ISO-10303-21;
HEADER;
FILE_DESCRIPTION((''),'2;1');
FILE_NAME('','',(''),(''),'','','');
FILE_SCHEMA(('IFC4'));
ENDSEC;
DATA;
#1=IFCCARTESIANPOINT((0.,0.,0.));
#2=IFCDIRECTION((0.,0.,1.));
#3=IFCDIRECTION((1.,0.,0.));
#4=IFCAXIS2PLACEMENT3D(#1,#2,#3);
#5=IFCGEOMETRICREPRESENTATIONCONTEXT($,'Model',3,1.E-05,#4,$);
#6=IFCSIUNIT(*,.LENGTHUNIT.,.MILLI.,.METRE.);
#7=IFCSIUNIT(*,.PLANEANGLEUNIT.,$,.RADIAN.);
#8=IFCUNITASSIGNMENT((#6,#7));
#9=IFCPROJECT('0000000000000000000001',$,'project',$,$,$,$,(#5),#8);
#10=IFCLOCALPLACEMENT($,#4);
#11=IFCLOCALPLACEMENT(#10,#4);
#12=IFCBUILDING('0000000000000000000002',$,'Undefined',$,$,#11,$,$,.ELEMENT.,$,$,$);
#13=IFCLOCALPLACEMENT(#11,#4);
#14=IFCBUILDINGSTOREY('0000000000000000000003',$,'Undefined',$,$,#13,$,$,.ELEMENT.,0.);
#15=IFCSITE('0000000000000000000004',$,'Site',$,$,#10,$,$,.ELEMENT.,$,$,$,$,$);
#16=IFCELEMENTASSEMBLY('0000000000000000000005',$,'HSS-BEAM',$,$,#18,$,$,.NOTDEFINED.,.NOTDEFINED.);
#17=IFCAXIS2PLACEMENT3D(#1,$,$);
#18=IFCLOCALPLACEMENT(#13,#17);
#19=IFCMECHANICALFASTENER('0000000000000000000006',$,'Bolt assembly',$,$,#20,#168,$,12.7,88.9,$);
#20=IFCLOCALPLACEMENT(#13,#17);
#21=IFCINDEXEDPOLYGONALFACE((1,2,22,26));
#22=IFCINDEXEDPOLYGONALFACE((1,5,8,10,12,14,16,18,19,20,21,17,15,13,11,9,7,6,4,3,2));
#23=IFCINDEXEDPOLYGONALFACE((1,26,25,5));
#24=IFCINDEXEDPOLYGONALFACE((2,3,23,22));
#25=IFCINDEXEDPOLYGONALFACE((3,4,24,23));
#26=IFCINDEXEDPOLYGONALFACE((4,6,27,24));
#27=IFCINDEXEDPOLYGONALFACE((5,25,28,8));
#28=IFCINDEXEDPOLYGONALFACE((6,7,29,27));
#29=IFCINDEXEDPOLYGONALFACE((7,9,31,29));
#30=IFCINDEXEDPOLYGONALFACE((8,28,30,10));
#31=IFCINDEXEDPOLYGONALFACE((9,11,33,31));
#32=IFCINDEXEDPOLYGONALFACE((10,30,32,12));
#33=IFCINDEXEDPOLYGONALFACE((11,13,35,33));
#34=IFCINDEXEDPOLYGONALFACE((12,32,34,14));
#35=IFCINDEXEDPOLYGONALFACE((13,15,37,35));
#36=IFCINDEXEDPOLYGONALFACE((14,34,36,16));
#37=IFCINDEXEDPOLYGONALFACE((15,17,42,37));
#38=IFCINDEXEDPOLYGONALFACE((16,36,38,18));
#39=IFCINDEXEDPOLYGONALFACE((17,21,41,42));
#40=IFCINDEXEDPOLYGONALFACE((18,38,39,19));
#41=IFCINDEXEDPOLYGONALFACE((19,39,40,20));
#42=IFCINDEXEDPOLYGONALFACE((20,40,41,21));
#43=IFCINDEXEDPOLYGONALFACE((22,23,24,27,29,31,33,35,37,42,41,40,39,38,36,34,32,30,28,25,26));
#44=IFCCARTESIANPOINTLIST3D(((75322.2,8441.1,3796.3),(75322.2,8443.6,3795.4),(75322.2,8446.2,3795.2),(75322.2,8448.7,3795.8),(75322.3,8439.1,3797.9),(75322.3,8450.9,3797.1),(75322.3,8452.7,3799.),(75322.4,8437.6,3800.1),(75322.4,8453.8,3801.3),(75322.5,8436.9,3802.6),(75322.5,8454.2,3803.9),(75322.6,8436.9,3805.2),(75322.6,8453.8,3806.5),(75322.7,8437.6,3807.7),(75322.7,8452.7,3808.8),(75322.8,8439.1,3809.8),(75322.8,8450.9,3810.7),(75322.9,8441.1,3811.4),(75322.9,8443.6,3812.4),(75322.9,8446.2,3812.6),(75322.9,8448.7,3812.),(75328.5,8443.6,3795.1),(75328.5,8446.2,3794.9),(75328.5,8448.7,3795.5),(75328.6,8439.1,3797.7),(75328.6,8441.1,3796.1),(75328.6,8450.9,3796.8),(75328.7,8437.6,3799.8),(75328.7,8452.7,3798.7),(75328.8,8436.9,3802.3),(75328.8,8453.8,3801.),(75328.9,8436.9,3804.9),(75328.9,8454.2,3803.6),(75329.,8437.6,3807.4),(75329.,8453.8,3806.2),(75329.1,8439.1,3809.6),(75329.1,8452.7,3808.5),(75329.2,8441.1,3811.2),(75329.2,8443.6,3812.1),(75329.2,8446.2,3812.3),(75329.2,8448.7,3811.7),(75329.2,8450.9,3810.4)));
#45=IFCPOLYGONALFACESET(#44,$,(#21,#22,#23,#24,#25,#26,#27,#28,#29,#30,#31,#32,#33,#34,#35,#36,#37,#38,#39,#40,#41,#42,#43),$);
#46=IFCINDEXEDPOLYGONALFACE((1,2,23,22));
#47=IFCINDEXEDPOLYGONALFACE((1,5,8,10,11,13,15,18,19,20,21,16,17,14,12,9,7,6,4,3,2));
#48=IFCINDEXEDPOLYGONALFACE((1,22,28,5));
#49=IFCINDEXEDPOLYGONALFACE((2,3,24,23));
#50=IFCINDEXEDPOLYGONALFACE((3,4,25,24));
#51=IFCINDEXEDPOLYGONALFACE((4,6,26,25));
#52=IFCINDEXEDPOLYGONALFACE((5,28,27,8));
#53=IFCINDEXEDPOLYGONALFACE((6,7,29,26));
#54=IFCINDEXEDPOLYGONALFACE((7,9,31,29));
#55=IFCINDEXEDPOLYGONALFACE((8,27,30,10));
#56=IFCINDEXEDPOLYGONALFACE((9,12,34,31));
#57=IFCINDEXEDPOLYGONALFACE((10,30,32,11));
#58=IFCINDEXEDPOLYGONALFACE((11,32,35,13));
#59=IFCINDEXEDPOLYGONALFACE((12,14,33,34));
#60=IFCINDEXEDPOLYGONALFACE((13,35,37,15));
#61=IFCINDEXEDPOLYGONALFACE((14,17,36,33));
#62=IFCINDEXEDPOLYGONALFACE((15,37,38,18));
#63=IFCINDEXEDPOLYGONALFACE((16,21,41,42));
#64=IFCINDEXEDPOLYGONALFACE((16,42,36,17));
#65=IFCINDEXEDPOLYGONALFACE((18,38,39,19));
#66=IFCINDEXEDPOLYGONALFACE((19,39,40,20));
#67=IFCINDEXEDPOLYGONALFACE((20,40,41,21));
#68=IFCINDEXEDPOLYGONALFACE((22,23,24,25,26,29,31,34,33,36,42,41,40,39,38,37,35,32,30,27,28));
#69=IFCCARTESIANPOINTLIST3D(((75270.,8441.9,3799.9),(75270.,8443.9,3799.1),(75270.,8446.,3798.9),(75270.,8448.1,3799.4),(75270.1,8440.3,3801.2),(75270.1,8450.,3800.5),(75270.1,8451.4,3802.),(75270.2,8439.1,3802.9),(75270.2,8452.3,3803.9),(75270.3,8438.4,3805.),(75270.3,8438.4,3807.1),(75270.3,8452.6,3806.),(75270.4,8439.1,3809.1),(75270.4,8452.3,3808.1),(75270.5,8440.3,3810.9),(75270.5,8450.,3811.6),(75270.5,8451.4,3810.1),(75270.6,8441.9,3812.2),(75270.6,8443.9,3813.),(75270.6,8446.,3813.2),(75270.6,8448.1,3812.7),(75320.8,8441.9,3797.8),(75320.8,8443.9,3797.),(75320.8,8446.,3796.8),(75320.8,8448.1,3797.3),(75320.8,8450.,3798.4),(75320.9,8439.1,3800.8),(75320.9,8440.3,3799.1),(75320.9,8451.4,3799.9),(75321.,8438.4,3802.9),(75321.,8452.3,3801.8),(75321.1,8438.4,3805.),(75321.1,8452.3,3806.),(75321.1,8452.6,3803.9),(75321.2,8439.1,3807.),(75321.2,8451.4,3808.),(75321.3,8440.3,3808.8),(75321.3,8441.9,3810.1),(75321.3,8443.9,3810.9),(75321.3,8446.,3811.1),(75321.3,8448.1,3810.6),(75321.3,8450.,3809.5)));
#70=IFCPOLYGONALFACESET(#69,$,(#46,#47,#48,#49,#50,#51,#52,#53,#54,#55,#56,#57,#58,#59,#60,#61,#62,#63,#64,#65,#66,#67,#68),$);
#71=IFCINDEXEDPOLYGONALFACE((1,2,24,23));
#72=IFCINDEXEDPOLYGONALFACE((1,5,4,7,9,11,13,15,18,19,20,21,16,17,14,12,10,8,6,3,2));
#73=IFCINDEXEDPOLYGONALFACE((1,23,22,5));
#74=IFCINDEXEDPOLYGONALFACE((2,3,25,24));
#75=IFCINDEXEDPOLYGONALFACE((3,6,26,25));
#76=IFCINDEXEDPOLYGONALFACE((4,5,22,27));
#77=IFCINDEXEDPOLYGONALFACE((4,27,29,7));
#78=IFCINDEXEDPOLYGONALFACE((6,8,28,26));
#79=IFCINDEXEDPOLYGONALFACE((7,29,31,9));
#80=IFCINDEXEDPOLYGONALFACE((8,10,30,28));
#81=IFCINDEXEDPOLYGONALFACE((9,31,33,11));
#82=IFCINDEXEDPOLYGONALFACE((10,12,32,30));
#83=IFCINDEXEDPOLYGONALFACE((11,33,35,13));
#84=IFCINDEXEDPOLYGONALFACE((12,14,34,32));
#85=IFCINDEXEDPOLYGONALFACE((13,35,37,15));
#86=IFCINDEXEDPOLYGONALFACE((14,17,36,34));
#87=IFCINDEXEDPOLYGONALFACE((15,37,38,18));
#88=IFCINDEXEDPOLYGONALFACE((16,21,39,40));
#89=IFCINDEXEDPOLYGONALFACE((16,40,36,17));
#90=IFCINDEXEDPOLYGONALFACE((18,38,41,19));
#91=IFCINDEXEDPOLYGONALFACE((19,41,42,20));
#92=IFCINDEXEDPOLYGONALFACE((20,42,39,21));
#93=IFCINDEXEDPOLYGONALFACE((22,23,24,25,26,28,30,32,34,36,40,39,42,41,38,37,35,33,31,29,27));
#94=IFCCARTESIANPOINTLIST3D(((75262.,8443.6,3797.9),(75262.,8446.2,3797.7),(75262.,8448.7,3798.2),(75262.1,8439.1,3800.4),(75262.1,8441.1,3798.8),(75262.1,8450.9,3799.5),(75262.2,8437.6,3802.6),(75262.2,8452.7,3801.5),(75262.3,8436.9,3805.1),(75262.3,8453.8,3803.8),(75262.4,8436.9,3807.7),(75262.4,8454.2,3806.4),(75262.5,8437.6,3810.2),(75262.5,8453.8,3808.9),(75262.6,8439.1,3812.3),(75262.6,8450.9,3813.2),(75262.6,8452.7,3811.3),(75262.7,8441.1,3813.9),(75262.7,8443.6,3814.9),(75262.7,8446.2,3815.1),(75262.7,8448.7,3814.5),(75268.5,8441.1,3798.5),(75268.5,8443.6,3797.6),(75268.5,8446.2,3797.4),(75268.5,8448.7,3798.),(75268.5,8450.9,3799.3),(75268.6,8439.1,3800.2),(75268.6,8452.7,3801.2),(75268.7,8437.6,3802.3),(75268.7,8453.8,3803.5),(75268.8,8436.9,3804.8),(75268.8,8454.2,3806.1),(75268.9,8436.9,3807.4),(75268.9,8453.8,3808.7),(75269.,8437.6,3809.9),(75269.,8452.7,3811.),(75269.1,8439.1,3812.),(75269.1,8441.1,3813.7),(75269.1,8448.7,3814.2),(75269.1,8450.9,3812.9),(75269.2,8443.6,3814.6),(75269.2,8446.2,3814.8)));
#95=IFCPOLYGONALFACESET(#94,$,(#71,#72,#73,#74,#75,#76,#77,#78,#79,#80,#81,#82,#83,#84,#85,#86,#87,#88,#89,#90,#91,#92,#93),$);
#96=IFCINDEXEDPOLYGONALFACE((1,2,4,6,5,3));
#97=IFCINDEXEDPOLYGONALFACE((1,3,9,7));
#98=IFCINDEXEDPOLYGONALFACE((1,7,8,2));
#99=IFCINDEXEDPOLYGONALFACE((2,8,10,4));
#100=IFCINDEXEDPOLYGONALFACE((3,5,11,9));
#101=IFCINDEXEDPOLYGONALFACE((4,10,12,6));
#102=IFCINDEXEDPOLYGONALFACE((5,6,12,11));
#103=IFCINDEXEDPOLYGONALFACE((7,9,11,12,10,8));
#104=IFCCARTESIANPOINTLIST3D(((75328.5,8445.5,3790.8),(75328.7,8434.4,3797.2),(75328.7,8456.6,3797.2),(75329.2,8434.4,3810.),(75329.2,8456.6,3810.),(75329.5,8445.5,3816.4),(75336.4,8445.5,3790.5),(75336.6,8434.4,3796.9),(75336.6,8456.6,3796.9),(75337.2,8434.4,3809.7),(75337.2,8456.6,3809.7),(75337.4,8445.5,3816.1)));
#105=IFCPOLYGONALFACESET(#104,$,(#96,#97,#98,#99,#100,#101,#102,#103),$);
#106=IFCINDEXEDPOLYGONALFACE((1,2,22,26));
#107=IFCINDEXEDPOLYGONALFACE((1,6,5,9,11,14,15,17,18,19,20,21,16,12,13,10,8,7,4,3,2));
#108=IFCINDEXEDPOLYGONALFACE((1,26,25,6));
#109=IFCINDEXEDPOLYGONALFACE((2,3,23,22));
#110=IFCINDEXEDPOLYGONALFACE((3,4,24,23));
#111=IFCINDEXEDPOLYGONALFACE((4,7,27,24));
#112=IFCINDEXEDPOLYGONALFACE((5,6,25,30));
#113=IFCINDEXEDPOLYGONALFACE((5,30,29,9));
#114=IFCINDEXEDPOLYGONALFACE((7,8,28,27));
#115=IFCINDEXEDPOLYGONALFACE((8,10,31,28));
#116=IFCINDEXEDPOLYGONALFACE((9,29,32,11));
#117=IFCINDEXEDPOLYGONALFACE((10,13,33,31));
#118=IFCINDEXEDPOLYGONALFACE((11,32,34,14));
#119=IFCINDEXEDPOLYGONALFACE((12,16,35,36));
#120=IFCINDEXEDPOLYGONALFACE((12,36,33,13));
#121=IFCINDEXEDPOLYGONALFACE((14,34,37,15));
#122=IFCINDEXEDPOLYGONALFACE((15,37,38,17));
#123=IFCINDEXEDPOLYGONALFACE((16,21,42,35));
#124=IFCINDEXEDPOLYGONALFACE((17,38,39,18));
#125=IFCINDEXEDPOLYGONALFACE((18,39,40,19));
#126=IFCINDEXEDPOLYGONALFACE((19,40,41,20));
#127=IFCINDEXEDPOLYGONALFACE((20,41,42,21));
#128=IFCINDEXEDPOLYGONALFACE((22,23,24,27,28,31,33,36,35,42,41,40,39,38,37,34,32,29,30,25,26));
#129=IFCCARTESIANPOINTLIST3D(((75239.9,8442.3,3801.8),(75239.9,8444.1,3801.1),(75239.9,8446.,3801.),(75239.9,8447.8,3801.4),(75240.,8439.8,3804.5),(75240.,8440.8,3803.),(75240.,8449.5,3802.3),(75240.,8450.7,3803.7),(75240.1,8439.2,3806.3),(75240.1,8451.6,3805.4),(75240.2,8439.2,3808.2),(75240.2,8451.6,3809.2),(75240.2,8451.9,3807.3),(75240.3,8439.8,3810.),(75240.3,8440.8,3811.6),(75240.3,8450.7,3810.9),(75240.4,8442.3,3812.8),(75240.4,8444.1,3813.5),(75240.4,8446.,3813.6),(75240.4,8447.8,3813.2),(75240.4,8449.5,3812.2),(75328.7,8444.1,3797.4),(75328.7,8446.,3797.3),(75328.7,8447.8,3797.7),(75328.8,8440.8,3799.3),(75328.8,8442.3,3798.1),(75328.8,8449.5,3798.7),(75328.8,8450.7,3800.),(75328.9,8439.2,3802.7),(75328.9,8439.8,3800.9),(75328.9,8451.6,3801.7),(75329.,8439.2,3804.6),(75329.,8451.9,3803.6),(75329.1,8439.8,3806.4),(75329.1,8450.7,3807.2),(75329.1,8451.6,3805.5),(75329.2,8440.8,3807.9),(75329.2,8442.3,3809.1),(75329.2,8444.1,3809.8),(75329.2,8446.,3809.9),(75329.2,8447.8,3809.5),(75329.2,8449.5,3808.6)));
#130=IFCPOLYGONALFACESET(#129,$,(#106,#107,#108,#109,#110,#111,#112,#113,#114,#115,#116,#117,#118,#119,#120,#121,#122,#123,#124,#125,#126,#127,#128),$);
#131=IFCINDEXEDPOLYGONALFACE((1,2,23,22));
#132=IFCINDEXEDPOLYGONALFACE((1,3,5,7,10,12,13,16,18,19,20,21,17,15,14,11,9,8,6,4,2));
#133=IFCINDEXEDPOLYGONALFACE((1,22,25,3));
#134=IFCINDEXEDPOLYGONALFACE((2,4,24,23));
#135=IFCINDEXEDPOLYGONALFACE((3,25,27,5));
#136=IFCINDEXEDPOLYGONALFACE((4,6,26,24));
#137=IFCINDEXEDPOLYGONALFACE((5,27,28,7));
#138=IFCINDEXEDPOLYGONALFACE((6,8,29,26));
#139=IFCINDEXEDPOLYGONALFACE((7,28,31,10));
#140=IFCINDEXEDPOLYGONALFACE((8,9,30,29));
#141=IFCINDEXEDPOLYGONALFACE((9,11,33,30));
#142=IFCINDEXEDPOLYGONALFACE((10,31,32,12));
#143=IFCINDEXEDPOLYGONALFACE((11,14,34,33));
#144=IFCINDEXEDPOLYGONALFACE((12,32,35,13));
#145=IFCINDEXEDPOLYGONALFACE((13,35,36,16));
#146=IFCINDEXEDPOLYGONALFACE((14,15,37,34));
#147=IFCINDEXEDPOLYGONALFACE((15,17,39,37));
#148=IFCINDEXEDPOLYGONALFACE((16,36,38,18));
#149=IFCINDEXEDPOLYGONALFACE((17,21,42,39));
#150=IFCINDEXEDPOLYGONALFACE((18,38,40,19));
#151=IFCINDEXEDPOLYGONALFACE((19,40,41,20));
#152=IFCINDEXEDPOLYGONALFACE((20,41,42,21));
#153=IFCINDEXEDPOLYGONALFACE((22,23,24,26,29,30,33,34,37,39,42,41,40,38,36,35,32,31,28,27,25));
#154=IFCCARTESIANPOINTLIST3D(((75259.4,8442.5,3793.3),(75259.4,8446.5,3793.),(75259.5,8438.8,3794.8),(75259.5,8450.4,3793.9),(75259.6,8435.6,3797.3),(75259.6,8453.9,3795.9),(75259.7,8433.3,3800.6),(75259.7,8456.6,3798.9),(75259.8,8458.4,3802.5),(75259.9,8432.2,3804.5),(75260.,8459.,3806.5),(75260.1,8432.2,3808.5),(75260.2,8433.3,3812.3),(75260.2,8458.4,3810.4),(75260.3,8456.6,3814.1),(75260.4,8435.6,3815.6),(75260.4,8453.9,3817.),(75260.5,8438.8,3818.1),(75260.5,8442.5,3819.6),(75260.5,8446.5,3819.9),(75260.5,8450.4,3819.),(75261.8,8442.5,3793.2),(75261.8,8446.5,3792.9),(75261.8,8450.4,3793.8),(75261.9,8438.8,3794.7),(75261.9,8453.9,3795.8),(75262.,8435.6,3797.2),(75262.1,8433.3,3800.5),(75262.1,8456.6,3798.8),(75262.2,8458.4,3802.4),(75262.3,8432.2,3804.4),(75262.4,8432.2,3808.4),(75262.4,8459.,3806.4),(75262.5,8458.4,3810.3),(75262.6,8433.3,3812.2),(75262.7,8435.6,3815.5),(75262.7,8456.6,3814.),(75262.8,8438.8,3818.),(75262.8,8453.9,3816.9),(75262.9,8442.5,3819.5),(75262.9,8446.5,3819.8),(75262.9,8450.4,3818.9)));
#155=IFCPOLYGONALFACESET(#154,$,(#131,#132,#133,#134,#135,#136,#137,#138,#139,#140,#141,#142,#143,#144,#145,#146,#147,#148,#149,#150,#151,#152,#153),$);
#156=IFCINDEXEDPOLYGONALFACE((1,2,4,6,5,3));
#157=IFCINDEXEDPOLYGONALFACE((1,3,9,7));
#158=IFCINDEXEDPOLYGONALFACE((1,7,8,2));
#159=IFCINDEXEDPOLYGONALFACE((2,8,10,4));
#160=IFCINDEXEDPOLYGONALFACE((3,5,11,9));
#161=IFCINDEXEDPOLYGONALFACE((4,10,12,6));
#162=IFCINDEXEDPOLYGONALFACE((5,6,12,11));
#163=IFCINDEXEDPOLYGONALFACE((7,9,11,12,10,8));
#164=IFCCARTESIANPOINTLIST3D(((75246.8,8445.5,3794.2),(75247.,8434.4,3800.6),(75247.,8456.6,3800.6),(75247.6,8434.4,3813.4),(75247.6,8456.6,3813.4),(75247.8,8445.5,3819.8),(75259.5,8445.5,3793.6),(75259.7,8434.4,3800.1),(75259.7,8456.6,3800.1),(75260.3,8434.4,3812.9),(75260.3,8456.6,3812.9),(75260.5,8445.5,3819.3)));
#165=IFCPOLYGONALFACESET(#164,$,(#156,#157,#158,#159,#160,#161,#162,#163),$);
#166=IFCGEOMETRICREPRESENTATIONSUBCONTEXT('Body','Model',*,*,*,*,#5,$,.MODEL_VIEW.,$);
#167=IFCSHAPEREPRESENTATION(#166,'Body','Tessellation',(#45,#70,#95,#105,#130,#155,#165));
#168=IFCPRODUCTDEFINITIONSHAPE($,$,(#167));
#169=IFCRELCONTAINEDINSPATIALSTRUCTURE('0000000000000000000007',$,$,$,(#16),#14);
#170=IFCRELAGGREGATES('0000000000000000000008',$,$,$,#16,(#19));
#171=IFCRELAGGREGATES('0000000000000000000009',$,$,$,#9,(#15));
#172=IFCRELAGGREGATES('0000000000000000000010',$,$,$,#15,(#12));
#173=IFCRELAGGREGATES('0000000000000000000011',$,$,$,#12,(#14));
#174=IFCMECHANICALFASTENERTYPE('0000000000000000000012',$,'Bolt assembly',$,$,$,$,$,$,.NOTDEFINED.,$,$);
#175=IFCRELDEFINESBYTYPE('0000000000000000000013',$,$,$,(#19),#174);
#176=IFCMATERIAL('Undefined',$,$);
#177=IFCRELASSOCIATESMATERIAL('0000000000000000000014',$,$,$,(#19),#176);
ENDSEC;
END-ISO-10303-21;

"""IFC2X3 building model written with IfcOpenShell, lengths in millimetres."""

from ifc_helpers import new_model, si_unit, frame, origin_with_axes, origin_2d_with_axis, place, context, subcontext, project, spatial, polyline, circle, outline, extrude, source, transform, mapped, material, type_object, element, aggregate, save


model = new_model("IFC2X3")

# Units and contexts
model_context = context("Model", 3, precision=1e-05, world=origin_with_axes())
body_context = subcontext(model_context, "Body", "Model", "MODEL_VIEW")
ifc_project = project(units=[si_unit("LENGTHUNIT", "METRE", prefix="MILLI"), si_unit("PLANEANGLEUNIT", "RADIAN")], contexts=[model_context])

# Site, building, storey
site_placement = place(None, origin_with_axes())
site = spatial("IfcSite", under=ifc_project, at=site_placement, Name="Site", CompositionType="ELEMENT")
building_placement = place(site_placement, origin_with_axes())
building = spatial("IfcBuilding", under=site, at=building_placement, Name="Undefined", CompositionType="ELEMENT")
storey_placement = place(building_placement, origin_with_axes())
storey = spatial("IfcBuildingStorey", under=building, at=storey_placement, Name="Undefined", CompositionType="ELEMENT", Elevation=0.0)

# Element assembly
assembly_1_placement = place(storey_placement, origin_with_axes())
assembly_1 = element("IfcElementAssembly", 1, at=assembly_1_placement, inside=storey, Name="HSS-BEAM", AssemblyPlace="NOTDEFINED", PredefinedType="NOTDEFINED")

# Mechanical fastener
ifc_material_1 = material(Name="Undefined")
mechanical_fastener_type = type_object("IfcMechanicalFastenerType", Name="Bolt assembly")
shared_shape_1 = source(origin_with_axes(), body_context, "Body", "SweptSolid", [
    extrude(circle(Radius=8.7, at=origin_2d_with_axis()), frame((0.0, -33.2, 0.0), z_axis=(0.0, 1.0, 0.0), x_axis=(1.0, 0.0, 0.0)), (0.0, 0.0, 1.0), 6.3),
    extrude(circle(Radius=7.1, at=origin_2d_with_axis()), frame((0.0, -25.4, 0.0), z_axis=(0.0, 1.0, 0.0), x_axis=(1.0, 0.0, 0.0)), (0.0, 0.0, 1.0), 50.8),
    extrude(circle(Radius=8.7, at=origin_2d_with_axis()), frame((0.0, 26.9, 0.0), z_axis=(0.0, 1.0, 0.0), x_axis=(1.0, 0.0, 0.0)), (0.0, 0.0, 1.0), 6.5),
    extrude(outline(polyline([(11.1, -6.4), (11.1, 6.4), (0.0, 12.8), (-11.1, 6.4), (-11.1, -6.4), (0.0, -12.8), (11.1, -6.4)])), frame((0.0, -41.3, 0.0), z_axis=(0.0, 1.0, 0.0), x_axis=(1.0, 0.0, 0.0)), (0.0, 0.0, 1.0), 7.9),
    extrude(circle(Radius=6.3, at=origin_2d_with_axis()), frame((0.0, -33.3, 0.0), z_axis=(0.0, 1.0, 0.0), x_axis=(1.0, 0.0, 0.0)), (0.0, 0.0, 1.0), 88.9),
    extrude(circle(Radius=13.5, at=origin_2d_with_axis()), frame((0.0, 33.3, 0.0), z_axis=(0.0, 1.0, 0.0), x_axis=(1.0, 0.0, 0.0)), (0.0, 0.0, 1.0), 2.4),
    extrude(outline(polyline([(11.1, -6.4), (11.1, 6.4), (0.0, 12.8), (-11.1, 6.4), (-11.1, -6.4), (0.0, -12.8), (11.1, -6.4)])), frame((0.0, 35.7, 0.0), z_axis=(0.0, 1.0, 0.0), x_axis=(1.0, 0.0, 0.0)), (0.0, 0.0, 1.0), 12.7),
])
mechanical_fastener_1_placement = place(assembly_1_placement, frame((75295.7, 8445.5, 3805.0), z_axis=(0.041337, 0.0, 0.999145), x_axis=(0.0, 1.0, 0.0)))
mechanical_fastener_1 = element("IfcMechanicalFastener", 2, at=mechanical_fastener_1_placement, type_object=mechanical_fastener_type, material=ifc_material_1, Name="Bolt assembly", NominalDiameter=12.7, NominalLength=88.9, context=body_context, shape_type="MappedRepresentation", body=[
    mapped(shared_shape_1, transform((0.0, 0.0, 0.0))),
])

aggregate(assembly_1, [mechanical_fastener_1])

save(model, "model.ifc")
